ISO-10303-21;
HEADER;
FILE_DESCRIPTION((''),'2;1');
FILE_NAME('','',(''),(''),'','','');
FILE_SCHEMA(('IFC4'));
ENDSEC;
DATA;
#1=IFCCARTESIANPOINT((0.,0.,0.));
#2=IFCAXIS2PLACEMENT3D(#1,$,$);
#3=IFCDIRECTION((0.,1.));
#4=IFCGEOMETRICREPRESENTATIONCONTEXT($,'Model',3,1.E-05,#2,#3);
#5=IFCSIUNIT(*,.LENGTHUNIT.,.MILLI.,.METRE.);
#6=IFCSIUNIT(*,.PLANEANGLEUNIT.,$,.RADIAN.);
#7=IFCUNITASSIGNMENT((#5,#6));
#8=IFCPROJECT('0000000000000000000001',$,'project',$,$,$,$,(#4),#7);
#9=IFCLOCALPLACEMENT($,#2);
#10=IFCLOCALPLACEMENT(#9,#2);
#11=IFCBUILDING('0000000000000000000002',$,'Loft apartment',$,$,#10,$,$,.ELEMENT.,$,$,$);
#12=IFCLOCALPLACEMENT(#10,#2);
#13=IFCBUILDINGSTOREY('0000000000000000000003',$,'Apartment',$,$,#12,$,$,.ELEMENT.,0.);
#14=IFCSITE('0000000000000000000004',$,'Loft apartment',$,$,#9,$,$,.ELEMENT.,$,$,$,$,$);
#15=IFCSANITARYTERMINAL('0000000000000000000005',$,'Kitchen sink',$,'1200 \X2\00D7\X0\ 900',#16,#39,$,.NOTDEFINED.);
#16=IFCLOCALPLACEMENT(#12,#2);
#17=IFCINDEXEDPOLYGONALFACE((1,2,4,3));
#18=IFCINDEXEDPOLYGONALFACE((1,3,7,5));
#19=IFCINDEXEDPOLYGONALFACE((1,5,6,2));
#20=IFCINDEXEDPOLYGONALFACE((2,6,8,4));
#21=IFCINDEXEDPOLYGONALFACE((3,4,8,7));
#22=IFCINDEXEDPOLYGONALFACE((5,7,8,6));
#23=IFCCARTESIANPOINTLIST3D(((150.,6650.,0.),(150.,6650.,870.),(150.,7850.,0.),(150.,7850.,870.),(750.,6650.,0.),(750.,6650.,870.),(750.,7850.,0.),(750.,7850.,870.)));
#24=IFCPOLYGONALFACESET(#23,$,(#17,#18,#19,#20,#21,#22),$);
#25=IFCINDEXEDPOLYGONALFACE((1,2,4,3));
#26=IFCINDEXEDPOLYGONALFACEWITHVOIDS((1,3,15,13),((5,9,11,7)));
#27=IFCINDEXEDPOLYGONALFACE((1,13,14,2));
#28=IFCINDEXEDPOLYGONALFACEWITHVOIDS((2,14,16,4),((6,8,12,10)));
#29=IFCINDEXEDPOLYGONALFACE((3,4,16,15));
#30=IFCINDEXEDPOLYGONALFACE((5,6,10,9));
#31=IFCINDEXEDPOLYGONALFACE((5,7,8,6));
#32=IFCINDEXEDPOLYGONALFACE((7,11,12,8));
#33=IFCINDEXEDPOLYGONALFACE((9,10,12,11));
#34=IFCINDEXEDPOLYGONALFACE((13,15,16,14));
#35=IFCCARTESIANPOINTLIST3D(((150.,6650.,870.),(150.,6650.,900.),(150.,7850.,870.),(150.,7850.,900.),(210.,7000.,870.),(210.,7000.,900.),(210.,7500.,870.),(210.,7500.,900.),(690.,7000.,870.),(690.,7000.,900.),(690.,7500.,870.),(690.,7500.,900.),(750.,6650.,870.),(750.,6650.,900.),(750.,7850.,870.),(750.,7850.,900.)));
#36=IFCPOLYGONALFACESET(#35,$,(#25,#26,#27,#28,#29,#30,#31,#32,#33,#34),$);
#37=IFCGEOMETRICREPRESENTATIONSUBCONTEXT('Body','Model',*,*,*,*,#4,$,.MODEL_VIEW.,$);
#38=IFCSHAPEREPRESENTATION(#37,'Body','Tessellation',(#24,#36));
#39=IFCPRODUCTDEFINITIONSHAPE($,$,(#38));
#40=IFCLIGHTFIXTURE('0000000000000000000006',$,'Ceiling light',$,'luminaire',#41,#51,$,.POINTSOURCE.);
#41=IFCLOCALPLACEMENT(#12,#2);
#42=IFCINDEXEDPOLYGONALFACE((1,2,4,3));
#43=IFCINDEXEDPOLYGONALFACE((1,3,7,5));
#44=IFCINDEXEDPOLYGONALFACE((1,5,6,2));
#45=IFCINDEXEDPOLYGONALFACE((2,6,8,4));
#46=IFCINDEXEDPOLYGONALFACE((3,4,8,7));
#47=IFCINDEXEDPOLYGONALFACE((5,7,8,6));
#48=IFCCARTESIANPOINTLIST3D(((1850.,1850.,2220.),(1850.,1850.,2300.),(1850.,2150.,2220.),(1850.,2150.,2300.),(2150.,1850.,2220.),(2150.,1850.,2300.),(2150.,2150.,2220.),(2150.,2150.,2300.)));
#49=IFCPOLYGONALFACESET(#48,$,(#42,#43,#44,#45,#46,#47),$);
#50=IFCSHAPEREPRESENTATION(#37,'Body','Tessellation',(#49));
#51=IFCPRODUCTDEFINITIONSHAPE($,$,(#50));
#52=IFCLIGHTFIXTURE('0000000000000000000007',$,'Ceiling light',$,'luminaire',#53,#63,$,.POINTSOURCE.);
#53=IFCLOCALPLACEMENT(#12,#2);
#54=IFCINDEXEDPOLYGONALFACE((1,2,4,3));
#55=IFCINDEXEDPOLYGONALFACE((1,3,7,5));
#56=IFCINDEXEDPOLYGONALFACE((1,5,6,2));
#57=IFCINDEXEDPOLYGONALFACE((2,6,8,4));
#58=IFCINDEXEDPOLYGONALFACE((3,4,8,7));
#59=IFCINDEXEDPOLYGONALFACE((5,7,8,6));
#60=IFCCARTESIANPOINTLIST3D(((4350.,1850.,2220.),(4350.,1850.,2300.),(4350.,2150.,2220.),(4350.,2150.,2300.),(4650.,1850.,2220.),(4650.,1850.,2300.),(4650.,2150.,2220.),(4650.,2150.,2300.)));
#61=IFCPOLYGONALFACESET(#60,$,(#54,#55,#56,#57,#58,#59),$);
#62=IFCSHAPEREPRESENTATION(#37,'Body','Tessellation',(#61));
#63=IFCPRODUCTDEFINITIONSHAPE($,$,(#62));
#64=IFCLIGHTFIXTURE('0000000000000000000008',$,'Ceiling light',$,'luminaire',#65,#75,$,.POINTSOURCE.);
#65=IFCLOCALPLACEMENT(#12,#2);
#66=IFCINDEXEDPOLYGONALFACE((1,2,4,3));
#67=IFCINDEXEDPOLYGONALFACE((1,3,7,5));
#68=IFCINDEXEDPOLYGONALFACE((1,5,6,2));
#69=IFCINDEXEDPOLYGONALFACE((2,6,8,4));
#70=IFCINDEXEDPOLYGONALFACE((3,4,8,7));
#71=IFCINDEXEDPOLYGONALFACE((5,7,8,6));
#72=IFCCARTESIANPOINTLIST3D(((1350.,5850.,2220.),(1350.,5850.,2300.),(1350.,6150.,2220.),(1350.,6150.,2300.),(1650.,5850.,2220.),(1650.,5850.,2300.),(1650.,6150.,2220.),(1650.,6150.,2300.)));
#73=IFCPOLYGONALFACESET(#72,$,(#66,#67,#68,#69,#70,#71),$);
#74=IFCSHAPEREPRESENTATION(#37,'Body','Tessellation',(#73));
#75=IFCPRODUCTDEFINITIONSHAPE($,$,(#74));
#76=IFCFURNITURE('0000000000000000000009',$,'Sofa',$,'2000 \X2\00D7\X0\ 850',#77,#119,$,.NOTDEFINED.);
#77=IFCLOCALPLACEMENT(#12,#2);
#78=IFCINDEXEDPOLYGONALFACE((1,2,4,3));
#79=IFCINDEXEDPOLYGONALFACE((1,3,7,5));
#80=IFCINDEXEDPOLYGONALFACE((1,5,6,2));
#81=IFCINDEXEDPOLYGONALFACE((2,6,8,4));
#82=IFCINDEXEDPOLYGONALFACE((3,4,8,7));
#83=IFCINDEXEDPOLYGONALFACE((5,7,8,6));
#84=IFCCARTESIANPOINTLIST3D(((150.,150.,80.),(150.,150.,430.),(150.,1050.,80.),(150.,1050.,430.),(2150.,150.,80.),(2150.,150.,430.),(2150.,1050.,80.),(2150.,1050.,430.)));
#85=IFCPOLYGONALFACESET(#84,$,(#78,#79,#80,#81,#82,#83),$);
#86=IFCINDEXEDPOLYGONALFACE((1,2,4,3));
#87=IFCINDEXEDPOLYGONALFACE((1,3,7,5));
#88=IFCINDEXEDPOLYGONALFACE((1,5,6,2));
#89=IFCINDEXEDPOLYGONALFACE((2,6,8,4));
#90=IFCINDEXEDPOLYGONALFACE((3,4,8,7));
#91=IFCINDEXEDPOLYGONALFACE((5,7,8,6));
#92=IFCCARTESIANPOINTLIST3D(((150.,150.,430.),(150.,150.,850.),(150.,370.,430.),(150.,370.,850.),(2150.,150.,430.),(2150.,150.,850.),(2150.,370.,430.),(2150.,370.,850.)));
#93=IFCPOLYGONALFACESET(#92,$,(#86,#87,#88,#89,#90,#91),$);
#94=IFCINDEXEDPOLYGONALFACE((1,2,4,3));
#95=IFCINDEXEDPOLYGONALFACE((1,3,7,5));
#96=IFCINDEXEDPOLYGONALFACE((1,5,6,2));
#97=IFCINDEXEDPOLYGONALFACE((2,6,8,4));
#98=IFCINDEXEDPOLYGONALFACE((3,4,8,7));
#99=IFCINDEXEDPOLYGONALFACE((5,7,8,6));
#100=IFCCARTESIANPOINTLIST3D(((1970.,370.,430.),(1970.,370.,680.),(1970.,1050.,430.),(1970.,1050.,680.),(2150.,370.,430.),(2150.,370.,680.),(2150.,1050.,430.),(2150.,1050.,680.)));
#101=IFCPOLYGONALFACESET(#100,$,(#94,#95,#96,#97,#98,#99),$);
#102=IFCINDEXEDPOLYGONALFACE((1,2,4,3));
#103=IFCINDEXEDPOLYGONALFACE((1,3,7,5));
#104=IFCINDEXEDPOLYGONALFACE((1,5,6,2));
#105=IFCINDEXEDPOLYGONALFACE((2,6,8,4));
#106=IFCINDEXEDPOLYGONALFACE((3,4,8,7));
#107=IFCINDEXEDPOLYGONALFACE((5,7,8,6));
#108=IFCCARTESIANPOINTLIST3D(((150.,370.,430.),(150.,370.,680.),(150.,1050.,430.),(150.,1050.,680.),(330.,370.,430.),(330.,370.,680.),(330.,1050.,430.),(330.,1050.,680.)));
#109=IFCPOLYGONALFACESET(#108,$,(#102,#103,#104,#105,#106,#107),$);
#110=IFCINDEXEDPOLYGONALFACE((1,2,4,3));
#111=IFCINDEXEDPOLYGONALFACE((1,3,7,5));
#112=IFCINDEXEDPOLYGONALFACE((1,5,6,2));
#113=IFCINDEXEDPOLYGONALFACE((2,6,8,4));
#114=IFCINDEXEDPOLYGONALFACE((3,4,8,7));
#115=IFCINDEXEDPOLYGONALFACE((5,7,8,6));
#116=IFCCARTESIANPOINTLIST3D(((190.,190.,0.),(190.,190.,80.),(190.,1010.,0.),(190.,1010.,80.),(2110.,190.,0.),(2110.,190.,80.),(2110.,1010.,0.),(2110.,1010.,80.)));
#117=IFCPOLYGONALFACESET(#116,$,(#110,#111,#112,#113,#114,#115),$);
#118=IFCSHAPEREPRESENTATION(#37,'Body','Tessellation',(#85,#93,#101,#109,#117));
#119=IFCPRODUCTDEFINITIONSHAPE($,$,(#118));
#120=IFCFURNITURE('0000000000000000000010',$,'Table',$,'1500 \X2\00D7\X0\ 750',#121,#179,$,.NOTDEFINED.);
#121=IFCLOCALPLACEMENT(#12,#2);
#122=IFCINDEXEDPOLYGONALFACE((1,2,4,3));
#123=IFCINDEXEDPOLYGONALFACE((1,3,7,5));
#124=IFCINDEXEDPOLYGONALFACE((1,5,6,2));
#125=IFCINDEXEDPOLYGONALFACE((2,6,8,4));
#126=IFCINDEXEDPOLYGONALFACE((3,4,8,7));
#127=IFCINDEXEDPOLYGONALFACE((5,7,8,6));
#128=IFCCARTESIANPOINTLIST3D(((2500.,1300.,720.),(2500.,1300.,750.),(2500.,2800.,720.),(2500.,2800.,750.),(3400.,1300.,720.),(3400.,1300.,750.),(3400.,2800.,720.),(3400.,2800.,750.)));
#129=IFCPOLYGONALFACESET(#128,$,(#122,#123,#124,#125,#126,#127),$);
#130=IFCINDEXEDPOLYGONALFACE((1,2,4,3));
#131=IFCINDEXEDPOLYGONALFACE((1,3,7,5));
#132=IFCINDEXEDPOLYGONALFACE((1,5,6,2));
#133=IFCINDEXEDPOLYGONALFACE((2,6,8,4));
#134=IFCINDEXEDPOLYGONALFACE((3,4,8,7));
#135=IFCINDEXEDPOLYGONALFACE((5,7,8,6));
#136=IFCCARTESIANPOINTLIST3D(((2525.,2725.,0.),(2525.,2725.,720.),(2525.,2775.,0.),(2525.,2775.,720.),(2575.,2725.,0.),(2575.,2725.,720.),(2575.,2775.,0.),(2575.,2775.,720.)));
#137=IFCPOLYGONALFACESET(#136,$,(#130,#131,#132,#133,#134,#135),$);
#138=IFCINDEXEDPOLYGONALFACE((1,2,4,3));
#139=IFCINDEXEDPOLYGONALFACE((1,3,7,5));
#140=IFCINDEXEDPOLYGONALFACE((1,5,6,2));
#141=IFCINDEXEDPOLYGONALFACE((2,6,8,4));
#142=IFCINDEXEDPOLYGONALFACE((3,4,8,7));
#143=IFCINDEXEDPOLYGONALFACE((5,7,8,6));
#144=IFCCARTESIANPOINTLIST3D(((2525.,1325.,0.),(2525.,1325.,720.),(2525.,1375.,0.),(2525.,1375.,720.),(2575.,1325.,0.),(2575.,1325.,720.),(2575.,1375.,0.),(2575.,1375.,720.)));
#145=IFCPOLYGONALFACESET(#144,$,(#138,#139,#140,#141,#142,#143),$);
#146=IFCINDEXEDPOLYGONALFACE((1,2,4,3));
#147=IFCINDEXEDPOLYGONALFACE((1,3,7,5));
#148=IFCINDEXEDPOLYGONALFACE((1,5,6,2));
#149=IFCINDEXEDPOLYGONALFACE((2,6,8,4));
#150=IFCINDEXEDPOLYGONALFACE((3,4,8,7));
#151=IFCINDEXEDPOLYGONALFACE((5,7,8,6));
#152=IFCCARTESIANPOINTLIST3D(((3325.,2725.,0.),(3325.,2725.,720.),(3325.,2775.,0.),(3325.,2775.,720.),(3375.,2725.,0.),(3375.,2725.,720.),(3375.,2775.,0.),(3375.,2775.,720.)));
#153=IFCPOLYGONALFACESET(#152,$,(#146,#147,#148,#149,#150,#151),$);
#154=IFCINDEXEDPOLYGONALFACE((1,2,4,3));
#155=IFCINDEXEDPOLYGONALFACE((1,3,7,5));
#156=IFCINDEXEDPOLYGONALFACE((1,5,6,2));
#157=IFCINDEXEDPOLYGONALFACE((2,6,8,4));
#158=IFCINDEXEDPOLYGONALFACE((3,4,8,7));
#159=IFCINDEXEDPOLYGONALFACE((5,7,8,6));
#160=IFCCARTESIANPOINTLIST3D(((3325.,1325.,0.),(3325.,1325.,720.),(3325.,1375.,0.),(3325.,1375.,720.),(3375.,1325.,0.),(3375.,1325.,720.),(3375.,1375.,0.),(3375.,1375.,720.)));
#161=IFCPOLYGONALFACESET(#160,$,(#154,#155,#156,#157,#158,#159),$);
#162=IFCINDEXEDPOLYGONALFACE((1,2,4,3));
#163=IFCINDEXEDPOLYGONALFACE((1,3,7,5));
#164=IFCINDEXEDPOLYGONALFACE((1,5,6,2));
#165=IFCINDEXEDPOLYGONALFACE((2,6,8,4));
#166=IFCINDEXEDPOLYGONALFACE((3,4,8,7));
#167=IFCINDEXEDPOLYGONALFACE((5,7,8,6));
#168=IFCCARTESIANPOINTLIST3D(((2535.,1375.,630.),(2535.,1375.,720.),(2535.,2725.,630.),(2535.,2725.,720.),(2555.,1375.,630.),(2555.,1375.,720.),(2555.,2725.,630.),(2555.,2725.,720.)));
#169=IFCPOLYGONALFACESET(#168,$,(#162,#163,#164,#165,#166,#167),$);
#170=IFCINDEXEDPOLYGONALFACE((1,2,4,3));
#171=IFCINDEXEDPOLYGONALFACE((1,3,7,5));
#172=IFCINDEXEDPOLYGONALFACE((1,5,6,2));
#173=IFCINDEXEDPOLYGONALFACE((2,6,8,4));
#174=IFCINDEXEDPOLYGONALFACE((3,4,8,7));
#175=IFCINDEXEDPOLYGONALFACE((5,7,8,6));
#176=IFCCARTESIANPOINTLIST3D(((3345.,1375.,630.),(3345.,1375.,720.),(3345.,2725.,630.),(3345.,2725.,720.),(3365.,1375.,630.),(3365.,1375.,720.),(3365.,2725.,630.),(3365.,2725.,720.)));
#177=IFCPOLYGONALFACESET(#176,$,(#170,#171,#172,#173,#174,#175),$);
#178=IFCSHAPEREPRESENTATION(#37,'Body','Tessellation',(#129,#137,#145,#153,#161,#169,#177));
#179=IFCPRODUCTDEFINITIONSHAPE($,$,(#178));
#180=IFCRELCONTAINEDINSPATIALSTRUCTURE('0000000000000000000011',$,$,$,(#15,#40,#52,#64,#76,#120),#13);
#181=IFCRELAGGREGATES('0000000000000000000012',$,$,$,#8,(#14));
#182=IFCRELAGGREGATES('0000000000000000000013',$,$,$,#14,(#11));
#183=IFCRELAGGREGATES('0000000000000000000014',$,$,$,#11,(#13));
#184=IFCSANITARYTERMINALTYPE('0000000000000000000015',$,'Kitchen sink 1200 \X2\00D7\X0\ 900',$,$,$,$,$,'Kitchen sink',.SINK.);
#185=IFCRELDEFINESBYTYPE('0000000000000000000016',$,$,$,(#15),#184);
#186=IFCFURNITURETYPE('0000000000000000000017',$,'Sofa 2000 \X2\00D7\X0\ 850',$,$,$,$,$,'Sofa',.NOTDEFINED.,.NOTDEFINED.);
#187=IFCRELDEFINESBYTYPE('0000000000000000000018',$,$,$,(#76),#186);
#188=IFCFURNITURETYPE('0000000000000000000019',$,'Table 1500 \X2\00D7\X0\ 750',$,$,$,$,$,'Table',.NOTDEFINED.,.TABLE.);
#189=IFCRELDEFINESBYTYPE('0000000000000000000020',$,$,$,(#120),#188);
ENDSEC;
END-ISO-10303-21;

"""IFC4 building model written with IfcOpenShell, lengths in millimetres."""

from ifc_helpers import new_model, entity, si_unit, direction, frame, origin, place, context, subcontext, project, spatial, polyline, outline, extrude, source, transform, mapped, type_object, type_shapes, element, save


model = new_model("IFC4")

# Units and contexts
model_context = context("Model", 3, precision=1e-05, world=origin(), true_north=direction((0.0, 1.0)))
body_context = subcontext(model_context, "Body", "Model", "MODEL_VIEW")
ifc_project = project(units=[si_unit("LENGTHUNIT", "METRE", prefix="MILLI"), si_unit("PLANEANGLEUNIT", "RADIAN")], contexts=[model_context])

# Site, building, storey
site_placement = place(None, origin())
site = spatial("IfcSite", under=ifc_project, at=site_placement, Name="Loft apartment", CompositionType="ELEMENT")
building_placement = place(site_placement, origin())
building = spatial("IfcBuilding", under=site, at=building_placement, Name="Loft apartment", CompositionType="ELEMENT")
storey_placement = place(building_placement, origin())
storey = spatial("IfcBuildingStorey", under=building, at=storey_placement, Name="Apartment", CompositionType="ELEMENT", Elevation=0.0)

# Sanitary terminal
sanitary_terminal_type = type_object("IfcSanitaryTerminalType", Name="Kitchen sink 1200 × 900", ElementType="Kitchen sink", PredefinedType="SINK")
cartesian_point_1 = entity("IfcCartesianPoint", [-600.0, 0.0])
cartesian_point_2 = entity("IfcCartesianPoint", [-250.0, 60.0])
shared_shape_1 = source(origin(), body_context, "Body", "SolidModel", [
    extrude(outline(polyline([(-600.0, 0.0), (600.0, 0.0), (600.0, 600.0), (-600.0, 600.0), (-600.0, 0.0)])), origin(), (0.0, 0.0, 1.0), 870.0),
    entity("IfcCsgSolid", entity("IfcBooleanResult", "DIFFERENCE", entity("IfcExtrudedAreaSolid", entity("IfcArbitraryClosedProfileDef", "AREA", None, entity("IfcPolyline", [cartesian_point_1, entity("IfcCartesianPoint", [600.0, 0.0]), entity("IfcCartesianPoint", [600.0, 600.0]), entity("IfcCartesianPoint", [-600.0, 600.0]), cartesian_point_1])), entity("IfcAxis2Placement3D", entity("IfcCartesianPoint", [0.0, 0.0, 870.0])), entity("IfcDirection", [0.0, 0.0, 1.0]), 30.0), entity("IfcExtrudedAreaSolid", entity("IfcArbitraryClosedProfileDef", "AREA", None, entity("IfcPolyline", [cartesian_point_2, entity("IfcCartesianPoint", [250.0, 60.0]), entity("IfcCartesianPoint", [250.0, 540.0]), entity("IfcCartesianPoint", [-250.0, 540.0]), cartesian_point_2])), entity("IfcAxis2Placement3D", entity("IfcCartesianPoint", [0.0, 0.0, 720.0])), entity("IfcDirection", [0.0, 0.0, 1.0]), 181.0))),
])
type_shapes(sanitary_terminal_type, [shared_shape_1])
sanitary_terminal_placement = place(storey_placement, frame((750.0, 7250.0, 0.0), z_axis=(0.0, 0.0, 1.0), x_axis=(0.0, 1.0, 0.0)))
element("IfcSanitaryTerminal", 1, at=sanitary_terminal_placement, inside=storey, type_object=sanitary_terminal_type, Name="Kitchen sink", ObjectType="1200 × 900", PredefinedType="NOTDEFINED", context=body_context, shape_type="MappedRepresentation", body=[
    mapped(shared_shape_1, transform((0.0, 0.0, 0.0))),
])

# Light fixtures
for number, where, z_axis, x_axis, name in (
    (2, (2000.0, 2000.0, 0.0), (0.0, 0.0, 1.0), (0.0, -1.0, 0.0), "Ceiling light"),
    (3, (4500.0, 2000.0, 0.0), (0.0, 0.0, 1.0), (0.0, -1.0, 0.0), "Ceiling light"),
    (4, (1500.0, 6000.0, 0.0), (0.0, 0.0, 1.0), (0.0, -1.0, 0.0), "Ceiling light"),
):
    element("IfcLightFixture", number, at=place(storey_placement, frame(where, z_axis=z_axis, x_axis=x_axis)), inside=storey, Name=name, ObjectType="luminaire", PredefinedType="POINTSOURCE", context=body_context, shape_type="SweptSolid", body=[
        extrude(outline(polyline([(-150.0, -150.0), (150.0, -150.0), (150.0, 150.0), (-150.0, 150.0), (-150.0, -150.0)])), frame((0.0, 0.0, 2220.0)), (0.0, 0.0, 1.0), 80.0),
    ])

# Furniture
furniture_type_1 = type_object("IfcFurnitureType", Name="Sofa 2000 × 850", ElementType="Sofa", AssemblyPlace="NOTDEFINED", PredefinedType="NOTDEFINED")
shared_shape_2 = source(origin(), body_context, "Body", "SweptSolid", [
    extrude(outline(polyline([(-1000.0, 0.0), (1000.0, 0.0), (1000.0, 900.0), (-1000.0, 900.0), (-1000.0, 0.0)])), frame((0.0, 0.0, 80.0)), (0.0, 0.0, 1.0), 350.0),
    extrude(outline(polyline([(-1000.0, 680.0), (1000.0, 680.0), (1000.0, 900.0), (-1000.0, 900.0), (-1000.0, 680.0)])), frame((0.0, 0.0, 430.0)), (0.0, 0.0, 1.0), 420.0),
    extrude(outline(polyline([(-1000.0, 0.0), (-820.0, 0.0), (-820.0, 680.0), (-1000.0, 680.0), (-1000.0, 0.0)])), frame((0.0, 0.0, 430.0)), (0.0, 0.0, 1.0), 250.0),
    extrude(outline(polyline([(820.0, 0.0), (1000.0, 0.0), (1000.0, 680.0), (820.0, 680.0), (820.0, 0.0)])), frame((0.0, 0.0, 430.0)), (0.0, 0.0, 1.0), 250.0),
    extrude(outline(polyline([(-960.0, 40.0), (960.0, 40.0), (960.0, 860.0), (-960.0, 860.0), (-960.0, 40.0)])), origin(), (0.0, 0.0, 1.0), 80.0),
])
type_shapes(furniture_type_1, [shared_shape_2])
furniture_1_placement = place(storey_placement, frame((1150.0, 1050.0, 0.0), z_axis=(0.0, 0.0, 1.0), x_axis=(-1.0, 0.0, 0.0)))
element("IfcFurniture", 5, at=furniture_1_placement, inside=storey, type_object=furniture_type_1, Name="Sofa", ObjectType="2000 × 850", PredefinedType="NOTDEFINED", context=body_context, shape_type="MappedRepresentation", body=[
    mapped(shared_shape_2, transform((0.0, 0.0, 0.0))),
])
furniture_type_2 = type_object("IfcFurnitureType", Name="Table 1500 × 750", ElementType="Table", AssemblyPlace="NOTDEFINED", PredefinedType="TABLE")
shared_shape_3 = source(origin(), body_context, "Body", "SweptSolid", [
    extrude(outline(polyline([(-750.0, -450.0), (750.0, -450.0), (750.0, 450.0), (-750.0, 450.0), (-750.0, -450.0)])), frame((0.0, 0.0, 720.0)), (0.0, 0.0, 1.0), 30.0),
    extrude(outline(polyline([(-725.0, -425.0), (-675.0, -425.0), (-675.0, -375.0), (-725.0, -375.0), (-725.0, -425.0)])), origin(), (0.0, 0.0, 1.0), 720.0),
    extrude(outline(polyline([(675.0, -425.0), (725.0, -425.0), (725.0, -375.0), (675.0, -375.0), (675.0, -425.0)])), origin(), (0.0, 0.0, 1.0), 720.0),
    extrude(outline(polyline([(-725.0, 375.0), (-675.0, 375.0), (-675.0, 425.0), (-725.0, 425.0), (-725.0, 375.0)])), origin(), (0.0, 0.0, 1.0), 720.0),
    extrude(outline(polyline([(675.0, 375.0), (725.0, 375.0), (725.0, 425.0), (675.0, 425.0), (675.0, 375.0)])), origin(), (0.0, 0.0, 1.0), 720.0),
    extrude(outline(polyline([(-675.0, -415.0), (675.0, -415.0), (675.0, -395.0), (-675.0, -395.0), (-675.0, -415.0)])), frame((0.0, 0.0, 630.0)), (0.0, 0.0, 1.0), 90.0),
    extrude(outline(polyline([(-675.0, 395.0), (675.0, 395.0), (675.0, 415.0), (-675.0, 415.0), (-675.0, 395.0)])), frame((0.0, 0.0, 630.0)), (0.0, 0.0, 1.0), 90.0),
])
type_shapes(furniture_type_2, [shared_shape_3])
furniture_2_placement = place(storey_placement, frame((2950.0, 2050.0, 0.0), z_axis=(0.0, 0.0, 1.0), x_axis=(0.0, -1.0, 0.0)))
element("IfcFurniture", 6, at=furniture_2_placement, inside=storey, type_object=furniture_type_2, Name="Table", ObjectType="1500 × 750", PredefinedType="NOTDEFINED", context=body_context, shape_type="MappedRepresentation", body=[
    mapped(shared_shape_3, transform((0.0, 0.0, 0.0))),
])

save(model, "model.ifc")
